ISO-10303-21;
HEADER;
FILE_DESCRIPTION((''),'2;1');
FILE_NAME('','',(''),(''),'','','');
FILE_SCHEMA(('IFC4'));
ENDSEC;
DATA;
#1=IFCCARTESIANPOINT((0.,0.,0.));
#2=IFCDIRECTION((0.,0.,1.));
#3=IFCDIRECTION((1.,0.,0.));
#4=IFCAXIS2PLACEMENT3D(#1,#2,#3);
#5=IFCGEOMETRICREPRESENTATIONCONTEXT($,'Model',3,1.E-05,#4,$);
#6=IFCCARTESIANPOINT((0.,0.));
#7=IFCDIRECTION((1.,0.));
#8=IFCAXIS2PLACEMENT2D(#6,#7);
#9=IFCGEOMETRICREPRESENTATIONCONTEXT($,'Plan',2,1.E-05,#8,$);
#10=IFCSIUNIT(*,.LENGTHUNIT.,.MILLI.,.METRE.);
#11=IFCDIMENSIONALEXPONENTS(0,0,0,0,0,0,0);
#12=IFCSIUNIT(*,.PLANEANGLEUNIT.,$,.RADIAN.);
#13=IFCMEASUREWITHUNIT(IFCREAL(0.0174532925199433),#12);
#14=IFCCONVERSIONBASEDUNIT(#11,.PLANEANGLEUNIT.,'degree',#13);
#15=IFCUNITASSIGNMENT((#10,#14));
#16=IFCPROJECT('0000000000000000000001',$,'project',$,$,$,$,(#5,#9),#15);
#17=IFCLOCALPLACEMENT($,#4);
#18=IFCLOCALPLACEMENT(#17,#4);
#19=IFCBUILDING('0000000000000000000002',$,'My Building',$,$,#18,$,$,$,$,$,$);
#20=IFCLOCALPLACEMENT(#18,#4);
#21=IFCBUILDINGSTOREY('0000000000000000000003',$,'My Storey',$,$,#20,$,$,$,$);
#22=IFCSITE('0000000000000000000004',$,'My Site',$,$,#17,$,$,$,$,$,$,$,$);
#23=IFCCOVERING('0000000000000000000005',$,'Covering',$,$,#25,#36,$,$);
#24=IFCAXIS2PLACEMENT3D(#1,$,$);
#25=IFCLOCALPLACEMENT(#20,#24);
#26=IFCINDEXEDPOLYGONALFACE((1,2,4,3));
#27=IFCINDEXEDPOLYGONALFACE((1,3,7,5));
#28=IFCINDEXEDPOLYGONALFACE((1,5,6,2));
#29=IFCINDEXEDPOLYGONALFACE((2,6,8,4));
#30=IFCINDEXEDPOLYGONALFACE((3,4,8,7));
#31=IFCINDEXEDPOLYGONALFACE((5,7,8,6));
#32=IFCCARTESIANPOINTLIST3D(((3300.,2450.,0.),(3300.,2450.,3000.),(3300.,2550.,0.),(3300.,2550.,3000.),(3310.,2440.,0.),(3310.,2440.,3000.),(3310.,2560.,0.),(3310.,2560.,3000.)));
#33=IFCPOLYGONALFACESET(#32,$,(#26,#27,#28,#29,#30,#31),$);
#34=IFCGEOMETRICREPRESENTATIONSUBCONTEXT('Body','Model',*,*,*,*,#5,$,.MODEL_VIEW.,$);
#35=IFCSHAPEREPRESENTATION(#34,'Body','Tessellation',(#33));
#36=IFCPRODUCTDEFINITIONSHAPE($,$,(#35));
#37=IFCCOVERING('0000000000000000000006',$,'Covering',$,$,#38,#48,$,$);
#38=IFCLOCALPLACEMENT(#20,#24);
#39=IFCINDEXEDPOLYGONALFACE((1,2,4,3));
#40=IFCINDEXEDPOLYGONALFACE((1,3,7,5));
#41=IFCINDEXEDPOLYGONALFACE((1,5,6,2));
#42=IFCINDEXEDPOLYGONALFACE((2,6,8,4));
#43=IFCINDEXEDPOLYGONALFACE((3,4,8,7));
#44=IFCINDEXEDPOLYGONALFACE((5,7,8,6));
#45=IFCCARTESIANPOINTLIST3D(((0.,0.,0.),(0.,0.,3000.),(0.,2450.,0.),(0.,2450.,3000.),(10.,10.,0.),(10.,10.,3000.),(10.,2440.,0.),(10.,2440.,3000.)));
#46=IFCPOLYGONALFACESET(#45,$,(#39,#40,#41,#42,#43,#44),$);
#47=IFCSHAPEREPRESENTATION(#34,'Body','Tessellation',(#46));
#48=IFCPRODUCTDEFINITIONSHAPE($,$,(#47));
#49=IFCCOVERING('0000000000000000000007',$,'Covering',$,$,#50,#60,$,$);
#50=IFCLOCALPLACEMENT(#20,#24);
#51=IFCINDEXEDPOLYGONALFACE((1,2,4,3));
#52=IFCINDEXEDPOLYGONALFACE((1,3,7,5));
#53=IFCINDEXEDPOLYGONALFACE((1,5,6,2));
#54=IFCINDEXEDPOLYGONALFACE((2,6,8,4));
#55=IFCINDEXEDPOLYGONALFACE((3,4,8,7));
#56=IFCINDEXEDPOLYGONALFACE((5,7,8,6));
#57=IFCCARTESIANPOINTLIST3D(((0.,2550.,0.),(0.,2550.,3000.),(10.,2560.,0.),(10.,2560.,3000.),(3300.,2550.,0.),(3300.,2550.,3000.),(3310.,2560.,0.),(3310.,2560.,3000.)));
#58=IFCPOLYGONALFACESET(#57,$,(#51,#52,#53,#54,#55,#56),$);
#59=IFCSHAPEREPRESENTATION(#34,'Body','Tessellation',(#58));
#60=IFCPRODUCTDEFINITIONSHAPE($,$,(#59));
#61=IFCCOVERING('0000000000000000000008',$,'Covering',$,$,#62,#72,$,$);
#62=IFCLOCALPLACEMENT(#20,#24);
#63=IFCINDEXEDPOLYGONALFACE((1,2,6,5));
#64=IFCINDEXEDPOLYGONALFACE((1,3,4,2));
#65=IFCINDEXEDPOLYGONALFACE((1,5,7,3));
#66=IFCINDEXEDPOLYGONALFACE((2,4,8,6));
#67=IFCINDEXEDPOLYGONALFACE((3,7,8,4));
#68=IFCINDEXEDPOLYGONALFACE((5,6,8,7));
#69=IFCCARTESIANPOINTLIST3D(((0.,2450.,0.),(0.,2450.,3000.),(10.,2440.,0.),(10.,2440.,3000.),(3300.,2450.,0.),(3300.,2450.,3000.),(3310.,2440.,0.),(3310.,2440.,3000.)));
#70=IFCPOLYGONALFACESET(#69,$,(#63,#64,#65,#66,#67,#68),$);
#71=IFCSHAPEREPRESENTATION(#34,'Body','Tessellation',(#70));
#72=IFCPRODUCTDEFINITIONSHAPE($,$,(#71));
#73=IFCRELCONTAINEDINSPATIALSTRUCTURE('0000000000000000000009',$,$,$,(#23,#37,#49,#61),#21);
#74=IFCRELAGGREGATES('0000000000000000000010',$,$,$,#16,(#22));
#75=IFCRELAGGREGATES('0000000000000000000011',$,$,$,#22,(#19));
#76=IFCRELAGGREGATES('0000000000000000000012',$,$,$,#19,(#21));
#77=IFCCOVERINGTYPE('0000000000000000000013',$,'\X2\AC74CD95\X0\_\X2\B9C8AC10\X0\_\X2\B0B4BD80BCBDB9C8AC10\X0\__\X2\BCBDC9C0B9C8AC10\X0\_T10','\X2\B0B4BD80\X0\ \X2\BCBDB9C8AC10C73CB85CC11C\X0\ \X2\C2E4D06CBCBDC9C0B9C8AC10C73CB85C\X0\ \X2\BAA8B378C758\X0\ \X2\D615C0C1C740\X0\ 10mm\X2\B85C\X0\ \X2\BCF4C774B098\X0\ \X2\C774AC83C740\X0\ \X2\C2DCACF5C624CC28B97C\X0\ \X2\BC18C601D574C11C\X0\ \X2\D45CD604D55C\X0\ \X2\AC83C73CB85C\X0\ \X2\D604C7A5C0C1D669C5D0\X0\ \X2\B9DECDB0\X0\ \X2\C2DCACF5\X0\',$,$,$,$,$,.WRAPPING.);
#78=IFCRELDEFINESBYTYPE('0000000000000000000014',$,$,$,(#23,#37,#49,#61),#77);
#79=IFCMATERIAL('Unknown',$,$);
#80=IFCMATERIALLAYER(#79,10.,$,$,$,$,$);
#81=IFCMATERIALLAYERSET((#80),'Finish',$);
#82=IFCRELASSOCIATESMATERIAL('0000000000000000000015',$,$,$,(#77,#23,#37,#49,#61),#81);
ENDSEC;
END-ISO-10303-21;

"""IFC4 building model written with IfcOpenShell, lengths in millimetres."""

from ifc_helpers import new_model, entity, si_unit, converted_unit, frame, origin_with_axes, origin_2d_with_axis, place, context, subcontext, project, spatial, line, indexed_curve, outline, extrude, material, layer, layer_set, layer_usage, type_object, element, save


model = new_model("IFC4")

# Units and contexts
model_context = context("Model", 3, precision=1e-05, world=origin_with_axes())
plan_context = context("Plan", 2, precision=1e-05, world=origin_2d_with_axis())
body_context = subcontext(model_context, "Body", "Model", "MODEL_VIEW")
ifc_project = project(units=[si_unit("LENGTHUNIT", "METRE", prefix="MILLI"), converted_unit("PLANEANGLEUNIT", "degree", entity("IfcReal", 0.0174532925199433), si_unit("PLANEANGLEUNIT", "RADIAN"), dimensions=[0, 0, 0, 0, 0, 0, 0])], contexts=[model_context, plan_context])

# Site, building, storey
site_placement = place(None, origin_with_axes())
site = spatial("IfcSite", under=ifc_project, at=site_placement, Name="My Site")
building_placement = place(site_placement, origin_with_axes())
building = spatial("IfcBuilding", under=site, at=building_placement, Name="My Building")
storey_placement = place(building_placement, origin_with_axes())
storey = spatial("IfcBuildingStorey", under=building, at=storey_placement, Name="My Storey")

# Shared definitions
ifc_material = material(Name="Unknown")

# Shared definitions
ifc_layer_1 = layer(ifc_material, 10.0)
ifc_layer_set_1 = layer_set([ifc_layer_1], Name="Finish")
covering_type_1 = type_object("IfcCoveringType", Name="건축_마감_내부벽마감__벽지마감_T10", Description="내부 벽마감으로서 실크벽지마감으로 모델의 형상은 10mm로 보이나 이것은 시공오차를 반영해서 표현한 것으로 현장상황에 맞춰 시공", PredefinedType="WRAPPING", material=ifc_layer_set_1)

# Coverings
ifc_layer_usage_1 = layer_usage(ifc_layer_set_1, "AXIS2", "POSITIVE", 0.0)
covering_1_placement = place(storey_placement, frame((3300.0, 2550.0, 0.0), z_axis=(0.0, 0.0, 1.0), x_axis=(0.0, -1.0, 0.0)))
element("IfcCovering", 1, at=covering_1_placement, inside=storey, type_object=covering_type_1, material=ifc_layer_usage_1, Name="Covering", context=body_context, shape_type="SweptSolid", body=[
    extrude(outline(indexed_curve([(0.0, 0.0), (-10.0, 10.0), (110.0, 10.0), (100.0, 0.0)], segments=[line(1, 2, 3, 4, 1)])), origin_with_axes(), (0.0, 0.0, 1.0), 3000.0),
])
ifc_layer_usage_2 = layer_usage(ifc_layer_set_1, "AXIS2", "POSITIVE", 0.0)
covering_2_placement = place(storey_placement, frame((0.0, 2450.0, 0.0), z_axis=(0.0, 0.0, 1.0), x_axis=(0.0, -1.0, 0.0)))
element("IfcCovering", 2, at=covering_2_placement, inside=storey, type_object=covering_type_1, material=ifc_layer_usage_2, Name="Covering", context=body_context, shape_type="SweptSolid", body=[
    extrude(outline(indexed_curve([(0.0, 0.0), (10.0, 10.0), (2440.0, 10.0), (2450.0, 0.0)], segments=[line(1, 2, 3, 4, 1)])), origin_with_axes(), (0.0, 0.0, 1.0), 3000.0),
])
ifc_layer_usage_3 = layer_usage(ifc_layer_set_1, "AXIS2", "NEGATIVE", 0.0)
covering_3_placement = place(storey_placement, frame((3300.0, 2550.0, 0.0), z_axis=(0.0, 0.0, 1.0), x_axis=(-1.0, 0.0, 0.0)))
element("IfcCovering", 3, at=covering_3_placement, inside=storey, type_object=covering_type_1, material=ifc_layer_usage_3, Name="Covering", context=body_context, shape_type="SweptSolid", body=[
    extrude(outline(indexed_curve([(-10.0, -10.0), (0.0, 0.0), (3300.0, 0.0), (3290.0, -10.0)], segments=[line(1, 2, 3, 4, 1)])), origin_with_axes(), (0.0, 0.0, 1.0), 3000.0),
])
ifc_layer_usage_4 = layer_usage(ifc_layer_set_1, "AXIS2", "POSITIVE", 0.0)
covering_4_placement = place(storey_placement, frame((3300.0, 2450.0, 0.0), z_axis=(0.0, 0.0, 1.0), x_axis=(-1.0, 0.0, 0.0)))
element("IfcCovering", 4, at=covering_4_placement, inside=storey, type_object=covering_type_1, material=ifc_layer_usage_4, Name="Covering", context=body_context, shape_type="SweptSolid", body=[
    extrude(outline(indexed_curve([(0.0, 0.0), (-10.0, 10.0), (3290.0, 10.0), (3300.0, 0.0)], segments=[line(1, 2, 3, 4, 1)])), origin_with_axes(), (0.0, 0.0, 1.0), 3000.0),
])

save(model, "model.ifc")
